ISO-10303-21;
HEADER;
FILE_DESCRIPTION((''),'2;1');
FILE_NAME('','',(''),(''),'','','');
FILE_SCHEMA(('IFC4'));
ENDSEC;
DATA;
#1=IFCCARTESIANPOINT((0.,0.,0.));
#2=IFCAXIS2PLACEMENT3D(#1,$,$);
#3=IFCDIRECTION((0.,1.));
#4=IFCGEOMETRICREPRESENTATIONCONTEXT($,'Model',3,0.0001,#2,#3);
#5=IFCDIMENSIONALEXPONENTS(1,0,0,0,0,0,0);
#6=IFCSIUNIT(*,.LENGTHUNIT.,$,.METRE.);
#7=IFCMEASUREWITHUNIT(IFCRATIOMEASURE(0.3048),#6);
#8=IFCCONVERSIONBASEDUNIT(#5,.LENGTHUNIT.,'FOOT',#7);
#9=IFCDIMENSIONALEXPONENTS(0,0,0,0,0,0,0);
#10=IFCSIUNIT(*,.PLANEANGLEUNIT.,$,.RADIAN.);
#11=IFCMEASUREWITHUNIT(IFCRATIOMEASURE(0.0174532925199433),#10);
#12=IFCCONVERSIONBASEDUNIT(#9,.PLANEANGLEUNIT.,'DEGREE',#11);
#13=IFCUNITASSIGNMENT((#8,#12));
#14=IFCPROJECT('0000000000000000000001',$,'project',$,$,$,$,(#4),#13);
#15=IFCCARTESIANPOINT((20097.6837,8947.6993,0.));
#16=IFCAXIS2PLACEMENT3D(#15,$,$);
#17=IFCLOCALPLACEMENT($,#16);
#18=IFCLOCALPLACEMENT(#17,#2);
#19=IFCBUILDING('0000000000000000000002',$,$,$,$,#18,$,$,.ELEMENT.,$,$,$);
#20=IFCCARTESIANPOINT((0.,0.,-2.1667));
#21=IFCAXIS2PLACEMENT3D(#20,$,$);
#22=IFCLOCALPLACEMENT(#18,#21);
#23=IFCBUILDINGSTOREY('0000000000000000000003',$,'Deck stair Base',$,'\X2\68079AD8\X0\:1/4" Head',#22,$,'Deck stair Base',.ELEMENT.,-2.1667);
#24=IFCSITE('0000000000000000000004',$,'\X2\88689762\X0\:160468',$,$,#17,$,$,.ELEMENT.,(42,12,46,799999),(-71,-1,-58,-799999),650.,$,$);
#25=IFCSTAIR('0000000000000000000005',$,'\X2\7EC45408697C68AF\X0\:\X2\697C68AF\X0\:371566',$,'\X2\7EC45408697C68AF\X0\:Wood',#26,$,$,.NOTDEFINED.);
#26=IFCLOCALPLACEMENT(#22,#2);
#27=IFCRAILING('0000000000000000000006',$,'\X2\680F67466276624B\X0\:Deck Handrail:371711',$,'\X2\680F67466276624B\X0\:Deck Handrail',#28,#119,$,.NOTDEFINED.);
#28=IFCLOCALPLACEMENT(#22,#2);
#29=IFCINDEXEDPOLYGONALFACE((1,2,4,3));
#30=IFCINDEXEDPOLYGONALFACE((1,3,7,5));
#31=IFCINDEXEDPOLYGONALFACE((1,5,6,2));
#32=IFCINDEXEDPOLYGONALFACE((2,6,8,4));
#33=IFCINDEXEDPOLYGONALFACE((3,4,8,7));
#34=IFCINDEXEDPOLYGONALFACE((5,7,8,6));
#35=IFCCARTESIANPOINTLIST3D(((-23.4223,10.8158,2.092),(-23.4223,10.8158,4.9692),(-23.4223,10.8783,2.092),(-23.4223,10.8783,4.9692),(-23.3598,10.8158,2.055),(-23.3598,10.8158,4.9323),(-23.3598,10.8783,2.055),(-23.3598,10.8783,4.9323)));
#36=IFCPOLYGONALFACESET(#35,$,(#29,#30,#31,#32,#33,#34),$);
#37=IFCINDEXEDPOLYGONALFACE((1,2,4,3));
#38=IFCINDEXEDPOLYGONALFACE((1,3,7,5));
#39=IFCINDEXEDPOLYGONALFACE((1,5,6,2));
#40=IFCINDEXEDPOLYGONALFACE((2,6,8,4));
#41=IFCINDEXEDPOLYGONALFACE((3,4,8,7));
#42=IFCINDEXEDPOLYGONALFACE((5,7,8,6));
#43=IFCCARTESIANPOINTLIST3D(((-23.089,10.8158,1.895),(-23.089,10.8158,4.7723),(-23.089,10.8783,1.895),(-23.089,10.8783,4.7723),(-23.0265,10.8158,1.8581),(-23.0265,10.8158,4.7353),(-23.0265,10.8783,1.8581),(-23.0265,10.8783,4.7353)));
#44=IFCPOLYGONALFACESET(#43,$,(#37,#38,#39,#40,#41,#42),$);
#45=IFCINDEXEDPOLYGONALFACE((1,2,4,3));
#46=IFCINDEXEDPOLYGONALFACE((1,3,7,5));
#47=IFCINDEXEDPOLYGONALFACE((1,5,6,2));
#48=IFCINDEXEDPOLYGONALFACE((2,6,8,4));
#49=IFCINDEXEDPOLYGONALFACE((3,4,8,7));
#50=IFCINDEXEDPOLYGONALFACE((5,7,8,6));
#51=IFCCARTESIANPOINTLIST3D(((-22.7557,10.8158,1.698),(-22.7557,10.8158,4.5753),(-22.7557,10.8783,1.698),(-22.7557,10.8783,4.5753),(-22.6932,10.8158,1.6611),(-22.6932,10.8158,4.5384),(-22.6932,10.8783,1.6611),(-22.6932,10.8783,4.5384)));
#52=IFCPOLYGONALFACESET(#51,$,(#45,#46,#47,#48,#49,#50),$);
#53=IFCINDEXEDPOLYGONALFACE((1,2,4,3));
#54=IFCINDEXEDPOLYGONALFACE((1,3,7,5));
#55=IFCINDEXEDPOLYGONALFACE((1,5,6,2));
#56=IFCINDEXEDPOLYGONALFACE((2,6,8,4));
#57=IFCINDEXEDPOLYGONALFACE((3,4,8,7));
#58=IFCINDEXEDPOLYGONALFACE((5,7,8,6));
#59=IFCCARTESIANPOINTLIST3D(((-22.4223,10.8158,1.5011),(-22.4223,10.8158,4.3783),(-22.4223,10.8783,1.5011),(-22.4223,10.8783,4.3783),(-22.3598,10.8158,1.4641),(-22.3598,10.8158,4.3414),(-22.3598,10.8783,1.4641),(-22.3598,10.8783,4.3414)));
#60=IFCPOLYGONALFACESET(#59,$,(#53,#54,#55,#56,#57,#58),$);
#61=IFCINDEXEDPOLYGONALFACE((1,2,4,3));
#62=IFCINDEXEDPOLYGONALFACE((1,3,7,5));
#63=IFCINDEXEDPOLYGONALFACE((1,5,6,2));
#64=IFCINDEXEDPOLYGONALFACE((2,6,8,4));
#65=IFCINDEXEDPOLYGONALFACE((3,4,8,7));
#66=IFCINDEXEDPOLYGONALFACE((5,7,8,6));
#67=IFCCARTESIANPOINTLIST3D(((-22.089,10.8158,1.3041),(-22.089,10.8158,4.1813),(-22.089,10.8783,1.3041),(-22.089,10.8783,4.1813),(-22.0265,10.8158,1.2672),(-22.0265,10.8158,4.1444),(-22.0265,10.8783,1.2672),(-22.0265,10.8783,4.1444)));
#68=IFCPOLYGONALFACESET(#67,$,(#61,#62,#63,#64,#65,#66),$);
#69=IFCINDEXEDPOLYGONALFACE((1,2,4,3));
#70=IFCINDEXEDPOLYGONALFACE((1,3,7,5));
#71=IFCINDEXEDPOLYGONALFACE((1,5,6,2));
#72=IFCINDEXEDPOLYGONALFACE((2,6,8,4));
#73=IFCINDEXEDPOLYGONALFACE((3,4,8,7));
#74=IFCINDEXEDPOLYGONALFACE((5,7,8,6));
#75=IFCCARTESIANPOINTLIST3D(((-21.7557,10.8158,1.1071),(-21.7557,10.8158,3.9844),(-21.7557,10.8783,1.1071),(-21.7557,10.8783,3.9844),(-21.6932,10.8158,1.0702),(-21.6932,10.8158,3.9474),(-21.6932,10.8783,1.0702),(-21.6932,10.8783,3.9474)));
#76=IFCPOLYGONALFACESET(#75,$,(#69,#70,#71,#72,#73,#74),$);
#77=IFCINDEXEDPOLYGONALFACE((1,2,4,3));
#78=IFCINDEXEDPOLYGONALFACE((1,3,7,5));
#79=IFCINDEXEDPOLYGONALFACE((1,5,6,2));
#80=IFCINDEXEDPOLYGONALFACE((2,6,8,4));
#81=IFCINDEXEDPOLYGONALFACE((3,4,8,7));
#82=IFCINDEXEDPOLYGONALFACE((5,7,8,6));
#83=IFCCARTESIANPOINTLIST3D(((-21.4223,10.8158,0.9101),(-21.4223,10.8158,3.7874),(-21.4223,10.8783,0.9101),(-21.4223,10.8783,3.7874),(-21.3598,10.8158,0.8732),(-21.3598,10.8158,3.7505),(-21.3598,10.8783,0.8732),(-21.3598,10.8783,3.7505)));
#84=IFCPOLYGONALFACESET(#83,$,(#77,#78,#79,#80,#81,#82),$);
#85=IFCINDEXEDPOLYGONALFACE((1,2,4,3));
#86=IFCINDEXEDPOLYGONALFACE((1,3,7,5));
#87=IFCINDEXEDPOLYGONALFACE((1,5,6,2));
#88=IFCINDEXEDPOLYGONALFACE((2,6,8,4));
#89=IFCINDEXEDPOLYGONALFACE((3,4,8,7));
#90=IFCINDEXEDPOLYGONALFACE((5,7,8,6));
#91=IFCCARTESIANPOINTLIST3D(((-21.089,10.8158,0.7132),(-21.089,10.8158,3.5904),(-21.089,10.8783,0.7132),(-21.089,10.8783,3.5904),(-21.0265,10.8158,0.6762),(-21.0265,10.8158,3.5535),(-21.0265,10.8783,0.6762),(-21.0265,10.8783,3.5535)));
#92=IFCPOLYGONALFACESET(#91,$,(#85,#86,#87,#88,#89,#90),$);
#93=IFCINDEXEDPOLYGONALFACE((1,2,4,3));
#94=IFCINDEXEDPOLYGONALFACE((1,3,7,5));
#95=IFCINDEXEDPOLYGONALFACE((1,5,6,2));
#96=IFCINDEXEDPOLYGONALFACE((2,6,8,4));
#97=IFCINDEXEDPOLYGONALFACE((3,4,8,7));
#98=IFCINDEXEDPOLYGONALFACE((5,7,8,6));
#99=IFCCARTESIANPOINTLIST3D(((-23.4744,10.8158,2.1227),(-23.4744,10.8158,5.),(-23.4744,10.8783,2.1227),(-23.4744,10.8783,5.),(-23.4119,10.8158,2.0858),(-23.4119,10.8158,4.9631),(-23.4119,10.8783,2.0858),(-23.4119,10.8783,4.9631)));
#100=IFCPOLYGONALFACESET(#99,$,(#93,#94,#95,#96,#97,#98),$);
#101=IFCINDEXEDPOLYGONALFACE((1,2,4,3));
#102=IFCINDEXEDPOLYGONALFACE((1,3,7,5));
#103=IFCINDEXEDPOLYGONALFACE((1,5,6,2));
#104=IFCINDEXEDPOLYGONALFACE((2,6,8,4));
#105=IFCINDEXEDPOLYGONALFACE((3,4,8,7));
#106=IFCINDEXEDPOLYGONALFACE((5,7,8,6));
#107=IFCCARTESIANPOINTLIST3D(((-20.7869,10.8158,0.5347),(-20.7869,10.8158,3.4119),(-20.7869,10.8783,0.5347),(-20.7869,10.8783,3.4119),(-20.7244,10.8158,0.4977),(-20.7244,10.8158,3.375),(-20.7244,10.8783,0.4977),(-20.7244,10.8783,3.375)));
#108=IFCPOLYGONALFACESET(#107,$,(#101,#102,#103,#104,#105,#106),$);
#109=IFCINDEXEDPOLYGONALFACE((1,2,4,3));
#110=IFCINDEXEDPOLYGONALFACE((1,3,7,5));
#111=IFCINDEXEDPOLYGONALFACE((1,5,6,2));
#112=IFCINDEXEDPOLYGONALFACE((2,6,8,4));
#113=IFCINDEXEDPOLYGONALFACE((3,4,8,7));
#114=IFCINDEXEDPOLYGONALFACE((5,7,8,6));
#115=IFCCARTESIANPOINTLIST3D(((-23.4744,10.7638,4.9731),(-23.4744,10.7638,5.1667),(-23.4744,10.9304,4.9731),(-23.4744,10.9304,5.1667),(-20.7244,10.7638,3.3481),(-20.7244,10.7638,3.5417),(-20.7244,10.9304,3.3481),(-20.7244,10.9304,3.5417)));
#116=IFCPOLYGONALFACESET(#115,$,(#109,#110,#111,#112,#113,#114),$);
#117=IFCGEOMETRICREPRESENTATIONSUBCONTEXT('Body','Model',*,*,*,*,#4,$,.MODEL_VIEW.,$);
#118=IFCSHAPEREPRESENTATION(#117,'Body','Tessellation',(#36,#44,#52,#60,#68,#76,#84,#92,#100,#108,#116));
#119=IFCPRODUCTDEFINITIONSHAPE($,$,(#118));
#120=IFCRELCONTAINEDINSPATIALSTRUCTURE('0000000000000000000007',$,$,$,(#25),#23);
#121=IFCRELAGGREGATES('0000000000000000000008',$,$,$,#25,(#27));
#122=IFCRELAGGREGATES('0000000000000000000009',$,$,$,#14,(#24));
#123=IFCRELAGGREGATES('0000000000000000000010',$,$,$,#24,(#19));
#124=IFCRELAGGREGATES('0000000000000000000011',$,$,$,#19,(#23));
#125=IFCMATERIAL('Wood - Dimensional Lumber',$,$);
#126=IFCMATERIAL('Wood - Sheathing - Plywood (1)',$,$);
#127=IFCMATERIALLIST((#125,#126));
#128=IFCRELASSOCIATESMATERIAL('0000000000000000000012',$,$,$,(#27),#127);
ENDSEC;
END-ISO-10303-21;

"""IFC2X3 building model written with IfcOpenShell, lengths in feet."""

from ifc_helpers import new_model, entity, si_unit, converted_unit, direction, frame, origin, place, context, subcontext, project, spatial, polyline, outline, extrude, material, material_list, element, aggregate, save


model = new_model("IFC2X3")

# Units and contexts
model_context = context("Model", 3, precision=0.0001, world=origin(), true_north=direction((0.0, 1.0)))
body_context = subcontext(model_context, "Body", "Model", "MODEL_VIEW")
ifc_project = project(units=[converted_unit("LENGTHUNIT", "FOOT", entity("IfcRatioMeasure", 0.3048), si_unit("LENGTHUNIT", "METRE"), dimensions=[1, 0, 0, 0, 0, 0, 0]), converted_unit("PLANEANGLEUNIT", "DEGREE", entity("IfcRatioMeasure", 0.0174532925199433), si_unit("PLANEANGLEUNIT", "RADIAN"), dimensions=[0, 0, 0, 0, 0, 0, 0])], contexts=[model_context])

# Site, building, storey
site_placement = place(None, frame((20097.6837, 8947.6993, 0.0)))
site = spatial("IfcSite", under=ifc_project, at=site_placement, Name="表面:160468", CompositionType="ELEMENT", RefLatitude=(42, 12, 46, 799999), RefLongitude=(-71, -1, -58, -799999), RefElevation=650.0)
building_placement = place(site_placement, origin())
building = spatial("IfcBuilding", under=site, at=building_placement, CompositionType="ELEMENT")
storey_placement = place(building_placement, frame((0.0, 0.0, -2.1667)))
storey = spatial("IfcBuildingStorey", under=building, at=storey_placement, Name="Deck stair Base", ObjectType="标高:1/4\" Head", LongName="Deck stair Base", CompositionType="ELEMENT", Elevation=-2.1667)

# Stair, railing
stair_placement = place(storey_placement, origin())
stair = element("IfcStair", 1, at=stair_placement, inside=storey, Name="组合楼梯:楼梯:371566", ObjectType="组合楼梯:Wood", ShapeType="NOTDEFINED")
ifc_material_1 = material(Name="Wood - Dimensional Lumber")
ifc_material_2 = material(Name="Wood - Sheathing - Plywood (1)")
ifc_material_list = material_list([ifc_material_1, ifc_material_2])
railing_placement = place(stair_placement, origin())
railing = element("IfcRailing", 2, at=railing_placement, material=ifc_material_list, Name="栏杆扶手:Deck Handrail:371711", ObjectType="栏杆扶手:Deck Handrail", PredefinedType="NOTDEFINED", context=body_context, shape_type="SweptSolid", body=[
    extrude(outline(polyline([(-1.4202, -0.0312), (1.4571, -0.0312), (1.4202, 0.0312), (-1.4571, 0.0312), (-1.4202, -0.0312)])), frame((-23.3911, 10.8158, 3.5121), z_axis=(0.0, 1.0, 0.0), x_axis=(0.0, 0.0, -1.0)), (0.0, 0.0, 1.0), 0.0625),
    extrude(outline(polyline([(-1.4202, -0.0312), (1.4571, -0.0312), (1.4202, 0.0312), (-1.4571, 0.0312), (-1.4202, -0.0312)])), frame((-23.0578, 10.8158, 3.3152), z_axis=(0.0, 1.0, 0.0), x_axis=(0.0, 0.0, -1.0)), (0.0, 0.0, 1.0), 0.0625),
    extrude(outline(polyline([(-1.4202, -0.0312), (1.4571, -0.0312), (1.4202, 0.0312), (-1.4571, 0.0312), (-1.4202, -0.0312)])), frame((-22.7244, 10.8158, 3.1182), z_axis=(0.0, 1.0, 0.0), x_axis=(0.0, 0.0, -1.0)), (0.0, 0.0, 1.0), 0.0625),
    extrude(outline(polyline([(-1.4202, -0.0312), (1.4571, -0.0312), (1.4202, 0.0312), (-1.4571, 0.0312), (-1.4202, -0.0312)])), frame((-22.3911, 10.8158, 2.9212), z_axis=(0.0, 1.0, 0.0), x_axis=(0.0, 0.0, -1.0)), (0.0, 0.0, 1.0), 0.0625),
    extrude(outline(polyline([(-1.4202, -0.0312), (1.4571, -0.0312), (1.4202, 0.0312), (-1.4571, 0.0312), (-1.4202, -0.0312)])), frame((-22.0578, 10.8158, 2.7242), z_axis=(0.0, 1.0, 0.0), x_axis=(0.0, 0.0, -1.0)), (0.0, 0.0, 1.0), 0.0625),
    extrude(outline(polyline([(-1.4202, -0.0312), (1.4571, -0.0312), (1.4202, 0.0312), (-1.4571, 0.0312), (-1.4202, -0.0312)])), frame((-21.7244, 10.8158, 2.5273), z_axis=(0.0, 1.0, 0.0), x_axis=(0.0, 0.0, -1.0)), (0.0, 0.0, 1.0), 0.0625),
    extrude(outline(polyline([(-1.4202, -0.0312), (1.4571, -0.0312), (1.4202, 0.0312), (-1.4571, 0.0312), (-1.4202, -0.0312)])), frame((-21.3911, 10.8158, 2.3303), z_axis=(0.0, 1.0, 0.0), x_axis=(0.0, 0.0, -1.0)), (0.0, 0.0, 1.0), 0.0625),
    extrude(outline(polyline([(-1.4202, -0.0312), (1.4571, -0.0312), (1.4202, 0.0312), (-1.4571, 0.0312), (-1.4202, -0.0312)])), frame((-21.0578, 10.8158, 2.1333), z_axis=(0.0, 1.0, 0.0), x_axis=(0.0, 0.0, -1.0)), (0.0, 0.0, 1.0), 0.0625),
    extrude(outline(polyline([(-1.4202, -0.0312), (1.4571, -0.0312), (1.4202, 0.0312), (-1.4571, 0.0312), (-1.4202, -0.0312)])), frame((-23.4432, 10.8158, 3.5429), z_axis=(0.0, 1.0, 0.0), x_axis=(0.0, 0.0, -1.0)), (0.0, 0.0, 1.0), 0.0625),
    extrude(outline(polyline([(-1.4202, -0.0312), (1.4571, -0.0312), (1.4202, 0.0312), (-1.4571, 0.0312), (-1.4202, -0.0312)])), frame((-20.7557, 10.8158, 1.9548), z_axis=(0.0, 1.0, 0.0), x_axis=(0.0, 0.0, -1.0)), (0.0, 0.0, 1.0), 0.0625),
    extrude(outline(polyline([(-1.6464, -0.0833), (1.5479, -0.0833), (1.6464, 0.0833), (-1.5479, 0.0833), (-1.6464, -0.0833)])), frame((-22.0994, 10.7638, 4.2574), z_axis=(0.0, 1.0, 0.0), x_axis=(-0.860927, 0.0, 0.508729)), (0.0, 0.0, 1.0), 0.1667),
])
aggregate(stair, [railing])

save(model, "model.ifc")
